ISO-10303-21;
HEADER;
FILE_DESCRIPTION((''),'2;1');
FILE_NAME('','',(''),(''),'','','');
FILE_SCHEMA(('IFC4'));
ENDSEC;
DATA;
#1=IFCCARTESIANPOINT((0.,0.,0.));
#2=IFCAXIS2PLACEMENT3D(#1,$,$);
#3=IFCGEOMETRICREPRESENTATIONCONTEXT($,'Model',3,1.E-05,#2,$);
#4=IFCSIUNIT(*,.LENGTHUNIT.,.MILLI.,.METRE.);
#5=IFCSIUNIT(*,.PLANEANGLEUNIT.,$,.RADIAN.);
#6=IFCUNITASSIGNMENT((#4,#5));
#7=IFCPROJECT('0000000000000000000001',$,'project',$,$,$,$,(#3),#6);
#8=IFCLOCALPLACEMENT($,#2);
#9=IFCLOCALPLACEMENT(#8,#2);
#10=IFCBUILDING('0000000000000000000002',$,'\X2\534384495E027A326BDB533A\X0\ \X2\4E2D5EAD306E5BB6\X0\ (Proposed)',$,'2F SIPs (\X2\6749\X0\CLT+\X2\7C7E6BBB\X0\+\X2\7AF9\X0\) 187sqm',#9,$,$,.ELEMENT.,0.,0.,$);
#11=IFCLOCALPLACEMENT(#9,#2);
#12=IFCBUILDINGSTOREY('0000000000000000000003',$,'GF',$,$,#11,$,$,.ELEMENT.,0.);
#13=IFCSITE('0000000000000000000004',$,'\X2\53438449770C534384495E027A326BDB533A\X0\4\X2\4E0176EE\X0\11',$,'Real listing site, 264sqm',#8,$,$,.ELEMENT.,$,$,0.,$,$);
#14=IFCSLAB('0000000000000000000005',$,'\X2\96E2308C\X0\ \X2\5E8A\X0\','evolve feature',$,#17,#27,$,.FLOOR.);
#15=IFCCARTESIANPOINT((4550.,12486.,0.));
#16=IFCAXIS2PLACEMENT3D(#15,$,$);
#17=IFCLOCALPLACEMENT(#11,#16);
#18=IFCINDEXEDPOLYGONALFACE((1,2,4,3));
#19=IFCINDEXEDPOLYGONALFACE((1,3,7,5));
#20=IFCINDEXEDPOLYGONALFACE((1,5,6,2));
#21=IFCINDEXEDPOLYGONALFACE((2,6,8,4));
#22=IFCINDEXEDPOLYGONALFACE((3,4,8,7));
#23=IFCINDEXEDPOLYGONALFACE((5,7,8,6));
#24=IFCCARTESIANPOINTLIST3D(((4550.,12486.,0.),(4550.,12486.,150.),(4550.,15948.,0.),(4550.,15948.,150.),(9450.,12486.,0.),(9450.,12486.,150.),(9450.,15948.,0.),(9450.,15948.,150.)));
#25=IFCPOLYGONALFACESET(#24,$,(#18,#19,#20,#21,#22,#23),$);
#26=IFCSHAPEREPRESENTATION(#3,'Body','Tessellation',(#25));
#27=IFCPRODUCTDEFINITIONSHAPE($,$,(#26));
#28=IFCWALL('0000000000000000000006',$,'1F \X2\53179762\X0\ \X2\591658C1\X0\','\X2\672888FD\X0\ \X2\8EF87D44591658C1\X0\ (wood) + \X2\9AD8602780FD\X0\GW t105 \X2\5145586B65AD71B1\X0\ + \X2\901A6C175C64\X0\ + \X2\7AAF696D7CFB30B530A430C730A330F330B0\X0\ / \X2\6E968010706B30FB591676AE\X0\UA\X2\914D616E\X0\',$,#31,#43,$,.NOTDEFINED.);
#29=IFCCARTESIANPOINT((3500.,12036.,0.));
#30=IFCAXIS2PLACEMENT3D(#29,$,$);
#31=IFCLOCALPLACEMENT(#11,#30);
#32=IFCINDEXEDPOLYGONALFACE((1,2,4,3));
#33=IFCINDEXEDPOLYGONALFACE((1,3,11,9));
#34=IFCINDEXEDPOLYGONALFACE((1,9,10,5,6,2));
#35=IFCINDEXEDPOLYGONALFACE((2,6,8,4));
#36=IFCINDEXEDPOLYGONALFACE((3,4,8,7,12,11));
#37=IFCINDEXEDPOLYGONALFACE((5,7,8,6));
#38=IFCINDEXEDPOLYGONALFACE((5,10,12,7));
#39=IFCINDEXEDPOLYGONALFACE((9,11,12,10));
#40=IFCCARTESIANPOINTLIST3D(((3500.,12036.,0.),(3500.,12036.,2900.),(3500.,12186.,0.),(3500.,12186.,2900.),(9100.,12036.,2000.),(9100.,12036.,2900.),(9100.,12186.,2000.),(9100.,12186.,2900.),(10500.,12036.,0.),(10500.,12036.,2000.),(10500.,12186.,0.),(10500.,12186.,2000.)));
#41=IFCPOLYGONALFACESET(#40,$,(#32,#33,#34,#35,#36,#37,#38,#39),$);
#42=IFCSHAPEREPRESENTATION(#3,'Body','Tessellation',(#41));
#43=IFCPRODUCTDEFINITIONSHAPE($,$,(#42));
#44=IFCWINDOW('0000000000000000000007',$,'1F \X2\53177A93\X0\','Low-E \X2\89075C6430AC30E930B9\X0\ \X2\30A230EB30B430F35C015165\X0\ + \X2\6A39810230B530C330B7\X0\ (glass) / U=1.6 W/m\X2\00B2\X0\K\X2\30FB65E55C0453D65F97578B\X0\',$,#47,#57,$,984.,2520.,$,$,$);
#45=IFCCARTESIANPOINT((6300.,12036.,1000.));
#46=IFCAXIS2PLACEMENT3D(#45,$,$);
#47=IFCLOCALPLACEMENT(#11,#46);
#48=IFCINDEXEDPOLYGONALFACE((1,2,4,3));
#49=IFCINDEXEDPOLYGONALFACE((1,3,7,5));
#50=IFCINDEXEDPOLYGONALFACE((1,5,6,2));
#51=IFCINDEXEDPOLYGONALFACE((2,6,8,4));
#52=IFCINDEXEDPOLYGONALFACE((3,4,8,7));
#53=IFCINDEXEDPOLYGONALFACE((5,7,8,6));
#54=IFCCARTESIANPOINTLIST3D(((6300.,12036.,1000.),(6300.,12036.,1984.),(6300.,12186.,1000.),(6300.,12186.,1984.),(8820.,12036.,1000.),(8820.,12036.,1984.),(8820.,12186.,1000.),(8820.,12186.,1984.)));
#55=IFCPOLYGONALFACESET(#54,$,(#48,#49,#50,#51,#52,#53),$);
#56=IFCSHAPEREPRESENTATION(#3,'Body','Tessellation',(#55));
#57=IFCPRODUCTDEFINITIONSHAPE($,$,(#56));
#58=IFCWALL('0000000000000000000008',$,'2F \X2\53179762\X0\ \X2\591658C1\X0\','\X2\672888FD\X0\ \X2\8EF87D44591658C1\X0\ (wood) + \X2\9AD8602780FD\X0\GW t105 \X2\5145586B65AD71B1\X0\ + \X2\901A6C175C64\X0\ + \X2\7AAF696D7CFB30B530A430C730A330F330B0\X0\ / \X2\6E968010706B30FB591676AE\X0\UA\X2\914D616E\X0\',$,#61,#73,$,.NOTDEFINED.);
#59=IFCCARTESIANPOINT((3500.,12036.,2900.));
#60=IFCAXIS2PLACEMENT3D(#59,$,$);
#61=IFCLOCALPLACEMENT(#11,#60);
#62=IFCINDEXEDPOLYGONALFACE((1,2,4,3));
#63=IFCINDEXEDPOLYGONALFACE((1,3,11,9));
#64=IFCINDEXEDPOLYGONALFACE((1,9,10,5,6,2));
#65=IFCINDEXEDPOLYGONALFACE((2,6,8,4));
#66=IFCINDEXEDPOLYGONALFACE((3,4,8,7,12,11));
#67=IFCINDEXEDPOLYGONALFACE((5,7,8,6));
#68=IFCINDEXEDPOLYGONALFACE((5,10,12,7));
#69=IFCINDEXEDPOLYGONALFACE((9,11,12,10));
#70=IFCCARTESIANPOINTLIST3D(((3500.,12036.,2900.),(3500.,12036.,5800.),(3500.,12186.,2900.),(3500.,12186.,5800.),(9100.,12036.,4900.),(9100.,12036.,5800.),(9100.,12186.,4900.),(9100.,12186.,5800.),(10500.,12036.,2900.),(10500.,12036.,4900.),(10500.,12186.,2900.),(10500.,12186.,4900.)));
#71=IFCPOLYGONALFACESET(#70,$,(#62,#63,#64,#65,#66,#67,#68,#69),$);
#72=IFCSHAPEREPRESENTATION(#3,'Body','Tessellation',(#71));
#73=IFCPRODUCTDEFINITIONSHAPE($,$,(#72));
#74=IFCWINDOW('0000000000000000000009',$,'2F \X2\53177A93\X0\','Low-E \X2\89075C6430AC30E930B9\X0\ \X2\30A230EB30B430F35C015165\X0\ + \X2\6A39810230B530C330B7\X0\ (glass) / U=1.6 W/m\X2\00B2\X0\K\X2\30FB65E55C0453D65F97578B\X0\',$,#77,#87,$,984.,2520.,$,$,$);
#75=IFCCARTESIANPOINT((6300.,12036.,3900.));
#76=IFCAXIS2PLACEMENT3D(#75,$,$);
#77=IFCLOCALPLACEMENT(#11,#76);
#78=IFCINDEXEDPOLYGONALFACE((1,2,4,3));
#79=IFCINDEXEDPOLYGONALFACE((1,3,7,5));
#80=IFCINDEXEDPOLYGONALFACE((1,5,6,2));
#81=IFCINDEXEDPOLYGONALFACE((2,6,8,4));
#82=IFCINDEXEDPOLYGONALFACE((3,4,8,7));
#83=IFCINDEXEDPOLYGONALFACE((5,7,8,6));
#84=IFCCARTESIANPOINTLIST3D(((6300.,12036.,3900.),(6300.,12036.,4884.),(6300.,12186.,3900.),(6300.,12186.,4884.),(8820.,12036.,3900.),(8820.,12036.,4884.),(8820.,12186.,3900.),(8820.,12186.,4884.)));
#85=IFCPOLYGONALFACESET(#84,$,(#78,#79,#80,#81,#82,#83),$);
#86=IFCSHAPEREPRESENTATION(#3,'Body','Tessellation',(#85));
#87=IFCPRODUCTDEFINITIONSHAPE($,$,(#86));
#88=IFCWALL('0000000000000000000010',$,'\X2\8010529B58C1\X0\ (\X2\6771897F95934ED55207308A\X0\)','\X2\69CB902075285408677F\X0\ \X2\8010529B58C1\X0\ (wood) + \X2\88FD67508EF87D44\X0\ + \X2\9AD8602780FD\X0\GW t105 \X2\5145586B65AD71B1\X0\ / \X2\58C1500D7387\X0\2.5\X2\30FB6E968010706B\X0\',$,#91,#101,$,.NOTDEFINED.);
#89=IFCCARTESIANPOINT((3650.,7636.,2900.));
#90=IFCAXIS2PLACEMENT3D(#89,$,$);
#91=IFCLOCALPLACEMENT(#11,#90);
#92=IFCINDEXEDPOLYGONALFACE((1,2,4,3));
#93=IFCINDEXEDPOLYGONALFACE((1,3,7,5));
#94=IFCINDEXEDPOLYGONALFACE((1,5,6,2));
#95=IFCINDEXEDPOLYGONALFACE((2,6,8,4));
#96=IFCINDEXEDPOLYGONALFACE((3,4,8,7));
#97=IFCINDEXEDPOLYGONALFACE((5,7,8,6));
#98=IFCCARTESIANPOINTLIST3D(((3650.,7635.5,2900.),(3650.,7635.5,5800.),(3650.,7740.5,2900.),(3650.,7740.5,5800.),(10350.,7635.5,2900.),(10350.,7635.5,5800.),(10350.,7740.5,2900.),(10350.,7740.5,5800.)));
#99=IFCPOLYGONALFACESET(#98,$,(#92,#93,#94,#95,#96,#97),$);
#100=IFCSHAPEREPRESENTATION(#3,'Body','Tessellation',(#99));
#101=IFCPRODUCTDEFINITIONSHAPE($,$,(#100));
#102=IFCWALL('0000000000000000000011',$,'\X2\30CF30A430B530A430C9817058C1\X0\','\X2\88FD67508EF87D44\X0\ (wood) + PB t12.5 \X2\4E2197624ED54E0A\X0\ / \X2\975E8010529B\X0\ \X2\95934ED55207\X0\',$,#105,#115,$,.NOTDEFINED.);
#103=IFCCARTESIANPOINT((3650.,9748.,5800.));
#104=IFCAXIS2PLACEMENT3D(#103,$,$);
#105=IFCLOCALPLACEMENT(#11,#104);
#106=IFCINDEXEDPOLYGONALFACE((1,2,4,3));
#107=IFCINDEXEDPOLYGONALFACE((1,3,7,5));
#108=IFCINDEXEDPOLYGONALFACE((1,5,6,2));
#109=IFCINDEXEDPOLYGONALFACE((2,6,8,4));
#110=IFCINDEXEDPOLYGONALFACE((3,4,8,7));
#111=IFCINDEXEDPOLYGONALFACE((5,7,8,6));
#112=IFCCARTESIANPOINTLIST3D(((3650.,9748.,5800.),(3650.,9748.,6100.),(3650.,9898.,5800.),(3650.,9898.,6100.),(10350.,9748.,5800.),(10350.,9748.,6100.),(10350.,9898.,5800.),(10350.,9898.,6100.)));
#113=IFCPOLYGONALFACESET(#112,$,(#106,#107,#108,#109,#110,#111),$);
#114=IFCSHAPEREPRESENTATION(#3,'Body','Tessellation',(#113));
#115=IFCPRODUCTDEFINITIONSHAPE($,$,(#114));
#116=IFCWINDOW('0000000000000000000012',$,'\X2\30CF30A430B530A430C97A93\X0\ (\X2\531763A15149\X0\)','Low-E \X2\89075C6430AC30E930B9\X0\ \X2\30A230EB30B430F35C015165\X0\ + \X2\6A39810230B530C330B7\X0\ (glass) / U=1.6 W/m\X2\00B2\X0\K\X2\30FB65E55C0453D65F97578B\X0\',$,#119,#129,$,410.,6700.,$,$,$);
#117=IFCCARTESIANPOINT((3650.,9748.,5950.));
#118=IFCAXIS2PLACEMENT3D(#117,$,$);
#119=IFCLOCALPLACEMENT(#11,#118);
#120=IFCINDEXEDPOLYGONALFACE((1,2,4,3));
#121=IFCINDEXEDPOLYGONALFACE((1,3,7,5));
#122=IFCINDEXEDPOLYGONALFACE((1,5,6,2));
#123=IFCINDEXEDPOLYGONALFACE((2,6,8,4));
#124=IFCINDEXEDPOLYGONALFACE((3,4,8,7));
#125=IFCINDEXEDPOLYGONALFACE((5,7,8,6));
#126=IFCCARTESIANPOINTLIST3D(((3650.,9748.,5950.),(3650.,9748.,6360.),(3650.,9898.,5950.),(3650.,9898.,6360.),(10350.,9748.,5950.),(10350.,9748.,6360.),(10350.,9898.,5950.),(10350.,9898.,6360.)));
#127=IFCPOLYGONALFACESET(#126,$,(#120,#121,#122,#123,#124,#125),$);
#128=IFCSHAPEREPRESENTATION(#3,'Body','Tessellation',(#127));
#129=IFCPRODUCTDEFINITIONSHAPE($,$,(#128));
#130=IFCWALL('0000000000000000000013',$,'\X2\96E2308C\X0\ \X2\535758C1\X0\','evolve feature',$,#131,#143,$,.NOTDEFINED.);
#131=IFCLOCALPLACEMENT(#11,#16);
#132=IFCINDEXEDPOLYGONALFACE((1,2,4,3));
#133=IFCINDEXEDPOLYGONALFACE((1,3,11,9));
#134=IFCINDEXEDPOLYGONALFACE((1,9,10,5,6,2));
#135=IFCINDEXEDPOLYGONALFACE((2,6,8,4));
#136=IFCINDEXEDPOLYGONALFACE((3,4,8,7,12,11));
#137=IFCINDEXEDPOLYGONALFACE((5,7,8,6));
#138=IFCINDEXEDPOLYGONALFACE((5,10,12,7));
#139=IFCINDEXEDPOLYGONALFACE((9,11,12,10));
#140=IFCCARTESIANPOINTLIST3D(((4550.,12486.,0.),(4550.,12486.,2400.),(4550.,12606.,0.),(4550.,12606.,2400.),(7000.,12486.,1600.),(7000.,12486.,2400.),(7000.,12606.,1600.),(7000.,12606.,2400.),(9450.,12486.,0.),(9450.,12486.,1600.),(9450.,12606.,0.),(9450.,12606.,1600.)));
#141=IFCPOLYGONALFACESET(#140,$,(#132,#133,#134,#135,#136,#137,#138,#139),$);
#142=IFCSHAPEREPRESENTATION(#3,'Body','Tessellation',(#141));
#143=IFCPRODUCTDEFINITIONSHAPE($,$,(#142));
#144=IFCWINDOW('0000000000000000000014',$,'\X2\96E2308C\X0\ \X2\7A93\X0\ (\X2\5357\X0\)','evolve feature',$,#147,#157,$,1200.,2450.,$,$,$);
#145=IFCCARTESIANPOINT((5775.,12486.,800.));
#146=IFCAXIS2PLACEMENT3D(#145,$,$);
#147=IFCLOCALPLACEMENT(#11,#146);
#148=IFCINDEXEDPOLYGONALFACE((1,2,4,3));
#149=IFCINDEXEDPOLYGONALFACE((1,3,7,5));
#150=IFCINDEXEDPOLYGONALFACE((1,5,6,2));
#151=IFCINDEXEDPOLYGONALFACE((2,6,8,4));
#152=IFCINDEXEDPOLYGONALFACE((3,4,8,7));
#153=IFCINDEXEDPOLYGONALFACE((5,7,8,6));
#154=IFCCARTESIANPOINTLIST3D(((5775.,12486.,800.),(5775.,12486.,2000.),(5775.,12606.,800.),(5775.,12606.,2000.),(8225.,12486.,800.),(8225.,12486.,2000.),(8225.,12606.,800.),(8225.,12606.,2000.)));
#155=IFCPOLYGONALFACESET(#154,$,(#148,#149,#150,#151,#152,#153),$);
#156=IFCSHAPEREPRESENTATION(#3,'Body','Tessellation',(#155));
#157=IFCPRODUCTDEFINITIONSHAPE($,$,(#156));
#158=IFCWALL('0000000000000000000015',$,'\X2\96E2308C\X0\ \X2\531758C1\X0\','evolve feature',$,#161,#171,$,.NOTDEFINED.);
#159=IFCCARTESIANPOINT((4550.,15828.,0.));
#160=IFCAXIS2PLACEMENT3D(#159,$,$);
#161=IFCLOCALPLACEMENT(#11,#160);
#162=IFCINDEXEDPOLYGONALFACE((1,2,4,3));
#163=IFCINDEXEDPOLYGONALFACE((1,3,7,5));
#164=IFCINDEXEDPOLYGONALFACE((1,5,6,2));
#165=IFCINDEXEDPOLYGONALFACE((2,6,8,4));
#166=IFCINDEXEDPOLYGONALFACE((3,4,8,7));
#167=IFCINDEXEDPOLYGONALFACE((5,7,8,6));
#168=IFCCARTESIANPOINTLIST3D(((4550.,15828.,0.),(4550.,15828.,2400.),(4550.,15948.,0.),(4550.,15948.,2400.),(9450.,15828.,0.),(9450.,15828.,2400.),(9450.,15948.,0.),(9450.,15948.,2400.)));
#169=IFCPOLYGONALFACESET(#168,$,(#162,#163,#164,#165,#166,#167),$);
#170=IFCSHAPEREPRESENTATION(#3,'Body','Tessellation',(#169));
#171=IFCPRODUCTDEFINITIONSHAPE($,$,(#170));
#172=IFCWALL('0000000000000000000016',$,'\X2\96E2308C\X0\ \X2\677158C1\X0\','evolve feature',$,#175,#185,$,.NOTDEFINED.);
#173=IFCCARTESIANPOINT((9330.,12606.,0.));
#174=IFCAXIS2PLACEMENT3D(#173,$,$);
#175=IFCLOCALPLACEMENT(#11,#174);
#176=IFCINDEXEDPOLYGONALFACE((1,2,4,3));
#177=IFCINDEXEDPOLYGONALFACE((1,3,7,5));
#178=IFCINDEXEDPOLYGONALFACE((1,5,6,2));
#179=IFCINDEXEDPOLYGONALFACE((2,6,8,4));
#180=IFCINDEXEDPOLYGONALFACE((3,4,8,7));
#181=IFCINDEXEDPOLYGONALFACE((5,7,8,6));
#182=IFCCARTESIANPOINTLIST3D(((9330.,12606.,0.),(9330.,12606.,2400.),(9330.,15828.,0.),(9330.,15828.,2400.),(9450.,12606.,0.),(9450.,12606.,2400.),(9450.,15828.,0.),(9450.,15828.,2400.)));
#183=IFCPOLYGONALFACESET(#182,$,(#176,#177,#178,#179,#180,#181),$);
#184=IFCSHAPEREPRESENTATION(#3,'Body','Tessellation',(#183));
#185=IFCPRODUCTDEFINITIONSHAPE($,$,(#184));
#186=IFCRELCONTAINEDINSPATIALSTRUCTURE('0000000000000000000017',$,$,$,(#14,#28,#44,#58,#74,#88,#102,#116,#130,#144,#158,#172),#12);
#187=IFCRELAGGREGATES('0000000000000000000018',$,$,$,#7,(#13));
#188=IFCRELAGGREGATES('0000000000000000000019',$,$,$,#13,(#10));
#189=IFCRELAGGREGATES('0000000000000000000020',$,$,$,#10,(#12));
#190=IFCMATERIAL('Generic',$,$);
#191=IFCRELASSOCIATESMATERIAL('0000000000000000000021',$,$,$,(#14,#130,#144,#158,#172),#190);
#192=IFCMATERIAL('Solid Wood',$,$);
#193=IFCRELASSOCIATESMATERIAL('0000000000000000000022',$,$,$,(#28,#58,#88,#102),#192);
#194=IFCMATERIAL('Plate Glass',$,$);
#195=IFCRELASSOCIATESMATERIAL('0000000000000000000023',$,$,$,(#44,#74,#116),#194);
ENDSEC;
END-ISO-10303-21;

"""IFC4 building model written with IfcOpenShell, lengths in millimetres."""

from ifc_helpers import new_model, si_unit, frame, frame_2d, origin, place, context, project, spatial, rectangle, extrude, material, element, fill, save


model = new_model("IFC4")

# Units and contexts
model_context = context("Model", 3, precision=1e-05, world=origin())
ifc_project = project(units=[si_unit("LENGTHUNIT", "METRE", prefix="MILLI"), si_unit("PLANEANGLEUNIT", "RADIAN")], contexts=[model_context])

# Site, building, storey
site_placement = place(None, origin())
site = spatial("IfcSite", under=ifc_project, at=site_placement, Name="千葉県千葉市稲毛区4丁目11", ObjectType="Real listing site, 264sqm", CompositionType="ELEMENT", RefElevation=0.0)
building_placement = place(site_placement, origin())
building = spatial("IfcBuilding", under=site, at=building_placement, Name="千葉市稲毛区 中庭の家 (Proposed)", ObjectType="2F SIPs (杉CLT+籾殻+竹) 187sqm", CompositionType="ELEMENT", ElevationOfRefHeight=0.0, ElevationOfTerrain=0.0)
storey_placement = place(building_placement, origin())
storey = spatial("IfcBuildingStorey", under=building, at=storey_placement, Name="GF", CompositionType="ELEMENT", Elevation=0.0)

# Slab
ifc_material_1 = material(Name="Generic")
slab_placement = place(storey_placement, frame((4550.0, 12486.0, 0.0)))
element("IfcSlab", 1, at=slab_placement, inside=storey, material=ifc_material_1, Name="離れ 床", Description="evolve feature", PredefinedType="FLOOR", context=model_context, shape_type="SweptSolid", body=[
    extrude(rectangle(XDim=4900.0, YDim=3462.0, at=frame_2d((2450.0, 1731.0))), frame((4550.0, 12486.0, 0.0)), (0.0, 0.0, 1.0), 150.0),
])

# Wall, opening, window
ifc_material_2 = material(Name="Solid Wood")
wall_1_placement = place(storey_placement, frame((3500.0, 12036.0, 0.0)))
wall_1 = element("IfcWall", 2, at=wall_1_placement, inside=storey, material=ifc_material_2, Name="1F 北面 外壁", Description="木製 軸組外壁 (wood) + 高性能GW t105 充填断熱 + 通気層 + 窯業系サイディング / 準耐火・外皮UA配慮", PredefinedType="NOTDEFINED", context=model_context, shape_type="SweptSolid", body=[
    extrude(rectangle(XDim=7000.0, YDim=150.0, at=frame_2d((3500.0, 75.0))), frame((3500.0, 12036.0, 0.0)), (0.0, 0.0, 1.0), 2900.0),
])
opening_1_placement = place(storey_placement, frame((6300.0, 12036.0, 1000.0)))
opening_1 = element("IfcOpeningElement", 3, at=opening_1_placement, cuts=wall_1, PredefinedType="NOTDEFINED", context=model_context, shape_type="SweptSolid", body=[
    extrude(rectangle(XDim=2520.0, YDim=150.0, at=frame_2d((1260.0, 75.0))), frame((6300.0, 12036.0, 1000.0)), (0.0, 0.0, 1.0), 984.0),
])
ifc_material_3 = material(Name="Plate Glass")
window_1_placement = place(storey_placement, frame((6300.0, 12036.0, 1000.0)))
window_1 = element("IfcWindow", 4, at=window_1_placement, inside=storey, material=ifc_material_3, Name="1F 北窓", Description="Low-E 複層ガラス アルゴン封入 + 樹脂サッシ (glass) / U=1.6 W/m²K・日射取得型", OverallHeight=984.0, OverallWidth=2520.0, context=model_context, shape_type="SweptSolid", body=[
    extrude(rectangle(XDim=2520.0, YDim=150.0, at=frame_2d((1260.0, 75.0))), frame((6300.0, 12036.0, 1000.0)), (0.0, 0.0, 1.0), 984.0),
])
fill(opening_1, window_1)

# Wall, opening, window
wall_2_placement = place(storey_placement, frame((3500.0, 12036.0, 2900.0)))
wall_2 = element("IfcWall", 5, at=wall_2_placement, inside=storey, material=ifc_material_2, Name="2F 北面 外壁", Description="木製 軸組外壁 (wood) + 高性能GW t105 充填断熱 + 通気層 + 窯業系サイディング / 準耐火・外皮UA配慮", PredefinedType="NOTDEFINED", context=model_context, shape_type="SweptSolid", body=[
    extrude(rectangle(XDim=7000.0, YDim=150.0, at=frame_2d((3500.0, 75.0))), frame((3500.0, 12036.0, 2900.0)), (0.0, 0.0, 1.0), 2900.0),
])
opening_2_placement = place(storey_placement, frame((6300.0, 12036.0, 3900.0)))
opening_2 = element("IfcOpeningElement", 6, at=opening_2_placement, cuts=wall_2, PredefinedType="NOTDEFINED", context=model_context, shape_type="SweptSolid", body=[
    extrude(rectangle(XDim=2520.0, YDim=150.0, at=frame_2d((1260.0, 75.0))), frame((6300.0, 12036.0, 3900.0)), (0.0, 0.0, 1.0), 984.0),
])
window_2_placement = place(storey_placement, frame((6300.0, 12036.0, 3900.0)))
window_2 = element("IfcWindow", 7, at=window_2_placement, inside=storey, material=ifc_material_3, Name="2F 北窓", Description="Low-E 複層ガラス アルゴン封入 + 樹脂サッシ (glass) / U=1.6 W/m²K・日射取得型", OverallHeight=984.0, OverallWidth=2520.0, context=model_context, shape_type="SweptSolid", body=[
    extrude(rectangle(XDim=2520.0, YDim=150.0, at=frame_2d((1260.0, 75.0))), frame((6300.0, 12036.0, 3900.0)), (0.0, 0.0, 1.0), 984.0),
])
fill(opening_2, window_2)

# Wall
wall_3_placement = place(storey_placement, frame((3650.0, 7636.0, 2900.0)))
element("IfcWall", 8, at=wall_3_placement, inside=storey, material=ifc_material_2, Name="耐力壁 (東西間仕切り)", Description="構造用合板 耐力壁 (wood) + 製材軸組 + 高性能GW t105 充填断熱 / 壁倍率2.5・準耐火", PredefinedType="NOTDEFINED", context=model_context, shape_type="SweptSolid", body=[
    extrude(rectangle(XDim=6700.0, YDim=105.0, at=frame_2d((3350.0, 52.0))), frame((3650.0, 7636.0, 2900.0)), (0.0, 0.0, 1.0), 2900.0),
])

# Walls, openings, windows
wall_4_placement = place(storey_placement, frame((3650.0, 9748.0, 5800.0)))
wall_4 = element("IfcWall", 9, at=wall_4_placement, inside=storey, material=ifc_material_2, Name="ハイサイド腰壁", Description="製材軸組 (wood) + PB t12.5 両面仕上 / 非耐力 間仕切", PredefinedType="NOTDEFINED", context=model_context, shape_type="SweptSolid", body=[
    extrude(rectangle(XDim=6700.0, YDim=150.0, at=frame_2d((3350.0, 75.0))), frame((3650.0, 9748.0, 5800.0)), (0.0, 0.0, 1.0), 700.0),
])
opening_3_placement = place(storey_placement, frame((3650.0, 9748.0, 5950.0)))
opening_3 = element("IfcOpeningElement", 10, at=opening_3_placement, cuts=wall_4, PredefinedType="NOTDEFINED", context=model_context, shape_type="SweptSolid", body=[
    extrude(rectangle(XDim=6700.0, YDim=150.0, at=frame_2d((3350.0, 75.0))), frame((3650.0, 9748.0, 5950.0)), (0.0, 0.0, 1.0), 410.0),
])
window_3_placement = place(storey_placement, frame((3650.0, 9748.0, 5950.0)))
window_3 = element("IfcWindow", 11, at=window_3_placement, inside=storey, material=ifc_material_3, Name="ハイサイド窓 (北採光)", Description="Low-E 複層ガラス アルゴン封入 + 樹脂サッシ (glass) / U=1.6 W/m²K・日射取得型", OverallHeight=410.0, OverallWidth=6700.0, context=model_context, shape_type="SweptSolid", body=[
    extrude(rectangle(XDim=6700.0, YDim=150.0, at=frame_2d((3350.0, 75.0))), frame((3650.0, 9748.0, 5950.0)), (0.0, 0.0, 1.0), 410.0),
])
fill(opening_3, window_3)
wall_5_placement = place(storey_placement, frame((4550.0, 12486.0, 0.0)))
wall_5 = element("IfcWall", 12, at=wall_5_placement, inside=storey, material=ifc_material_1, Name="離れ 南壁", Description="evolve feature", PredefinedType="NOTDEFINED", context=model_context, shape_type="SweptSolid", body=[
    extrude(rectangle(XDim=4900.0, YDim=120.0, at=frame_2d((2450.0, 60.0))), frame((4550.0, 12486.0, 0.0)), (0.0, 0.0, 1.0), 2400.0),
])
opening_4_placement = place(storey_placement, frame((5775.0, 12486.0, 800.0)))
opening_4 = element("IfcOpeningElement", 13, at=opening_4_placement, cuts=wall_5, PredefinedType="NOTDEFINED", context=model_context, shape_type="SweptSolid", body=[
    extrude(rectangle(XDim=2450.0, YDim=120.0, at=frame_2d((1225.0, 60.0))), frame((5775.0, 12486.0, 800.0)), (0.0, 0.0, 1.0), 1200.0),
])
window_4_placement = place(storey_placement, frame((5775.0, 12486.0, 800.0)))
window_4 = element("IfcWindow", 14, at=window_4_placement, inside=storey, material=ifc_material_1, Name="離れ 窓 (南)", Description="evolve feature", OverallHeight=1200.0, OverallWidth=2450.0, context=model_context, shape_type="SweptSolid", body=[
    extrude(rectangle(XDim=2450.0, YDim=120.0, at=frame_2d((1225.0, 60.0))), frame((5775.0, 12486.0, 800.0)), (0.0, 0.0, 1.0), 1200.0),
])
fill(opening_4, window_4)

# Walls
wall_6_placement = place(storey_placement, frame((4550.0, 15828.0, 0.0)))
element("IfcWall", 15, at=wall_6_placement, inside=storey, material=ifc_material_1, Name="離れ 北壁", Description="evolve feature", PredefinedType="NOTDEFINED", context=model_context, shape_type="SweptSolid", body=[
    extrude(rectangle(XDim=4900.0, YDim=120.0, at=frame_2d((2450.0, 60.0))), frame((4550.0, 15828.0, 0.0)), (0.0, 0.0, 1.0), 2400.0),
])
wall_7_placement = place(storey_placement, frame((9330.0, 12606.0, 0.0)))
element("IfcWall", 16, at=wall_7_placement, inside=storey, material=ifc_material_1, Name="離れ 東壁", Description="evolve feature", PredefinedType="NOTDEFINED", context=model_context, shape_type="SweptSolid", body=[
    extrude(rectangle(XDim=120.0, YDim=3222.0, at=frame_2d((60.0, 1611.0))), frame((9330.0, 12606.0, 0.0)), (0.0, 0.0, 1.0), 2400.0),
])

save(model, "model.ifc")
